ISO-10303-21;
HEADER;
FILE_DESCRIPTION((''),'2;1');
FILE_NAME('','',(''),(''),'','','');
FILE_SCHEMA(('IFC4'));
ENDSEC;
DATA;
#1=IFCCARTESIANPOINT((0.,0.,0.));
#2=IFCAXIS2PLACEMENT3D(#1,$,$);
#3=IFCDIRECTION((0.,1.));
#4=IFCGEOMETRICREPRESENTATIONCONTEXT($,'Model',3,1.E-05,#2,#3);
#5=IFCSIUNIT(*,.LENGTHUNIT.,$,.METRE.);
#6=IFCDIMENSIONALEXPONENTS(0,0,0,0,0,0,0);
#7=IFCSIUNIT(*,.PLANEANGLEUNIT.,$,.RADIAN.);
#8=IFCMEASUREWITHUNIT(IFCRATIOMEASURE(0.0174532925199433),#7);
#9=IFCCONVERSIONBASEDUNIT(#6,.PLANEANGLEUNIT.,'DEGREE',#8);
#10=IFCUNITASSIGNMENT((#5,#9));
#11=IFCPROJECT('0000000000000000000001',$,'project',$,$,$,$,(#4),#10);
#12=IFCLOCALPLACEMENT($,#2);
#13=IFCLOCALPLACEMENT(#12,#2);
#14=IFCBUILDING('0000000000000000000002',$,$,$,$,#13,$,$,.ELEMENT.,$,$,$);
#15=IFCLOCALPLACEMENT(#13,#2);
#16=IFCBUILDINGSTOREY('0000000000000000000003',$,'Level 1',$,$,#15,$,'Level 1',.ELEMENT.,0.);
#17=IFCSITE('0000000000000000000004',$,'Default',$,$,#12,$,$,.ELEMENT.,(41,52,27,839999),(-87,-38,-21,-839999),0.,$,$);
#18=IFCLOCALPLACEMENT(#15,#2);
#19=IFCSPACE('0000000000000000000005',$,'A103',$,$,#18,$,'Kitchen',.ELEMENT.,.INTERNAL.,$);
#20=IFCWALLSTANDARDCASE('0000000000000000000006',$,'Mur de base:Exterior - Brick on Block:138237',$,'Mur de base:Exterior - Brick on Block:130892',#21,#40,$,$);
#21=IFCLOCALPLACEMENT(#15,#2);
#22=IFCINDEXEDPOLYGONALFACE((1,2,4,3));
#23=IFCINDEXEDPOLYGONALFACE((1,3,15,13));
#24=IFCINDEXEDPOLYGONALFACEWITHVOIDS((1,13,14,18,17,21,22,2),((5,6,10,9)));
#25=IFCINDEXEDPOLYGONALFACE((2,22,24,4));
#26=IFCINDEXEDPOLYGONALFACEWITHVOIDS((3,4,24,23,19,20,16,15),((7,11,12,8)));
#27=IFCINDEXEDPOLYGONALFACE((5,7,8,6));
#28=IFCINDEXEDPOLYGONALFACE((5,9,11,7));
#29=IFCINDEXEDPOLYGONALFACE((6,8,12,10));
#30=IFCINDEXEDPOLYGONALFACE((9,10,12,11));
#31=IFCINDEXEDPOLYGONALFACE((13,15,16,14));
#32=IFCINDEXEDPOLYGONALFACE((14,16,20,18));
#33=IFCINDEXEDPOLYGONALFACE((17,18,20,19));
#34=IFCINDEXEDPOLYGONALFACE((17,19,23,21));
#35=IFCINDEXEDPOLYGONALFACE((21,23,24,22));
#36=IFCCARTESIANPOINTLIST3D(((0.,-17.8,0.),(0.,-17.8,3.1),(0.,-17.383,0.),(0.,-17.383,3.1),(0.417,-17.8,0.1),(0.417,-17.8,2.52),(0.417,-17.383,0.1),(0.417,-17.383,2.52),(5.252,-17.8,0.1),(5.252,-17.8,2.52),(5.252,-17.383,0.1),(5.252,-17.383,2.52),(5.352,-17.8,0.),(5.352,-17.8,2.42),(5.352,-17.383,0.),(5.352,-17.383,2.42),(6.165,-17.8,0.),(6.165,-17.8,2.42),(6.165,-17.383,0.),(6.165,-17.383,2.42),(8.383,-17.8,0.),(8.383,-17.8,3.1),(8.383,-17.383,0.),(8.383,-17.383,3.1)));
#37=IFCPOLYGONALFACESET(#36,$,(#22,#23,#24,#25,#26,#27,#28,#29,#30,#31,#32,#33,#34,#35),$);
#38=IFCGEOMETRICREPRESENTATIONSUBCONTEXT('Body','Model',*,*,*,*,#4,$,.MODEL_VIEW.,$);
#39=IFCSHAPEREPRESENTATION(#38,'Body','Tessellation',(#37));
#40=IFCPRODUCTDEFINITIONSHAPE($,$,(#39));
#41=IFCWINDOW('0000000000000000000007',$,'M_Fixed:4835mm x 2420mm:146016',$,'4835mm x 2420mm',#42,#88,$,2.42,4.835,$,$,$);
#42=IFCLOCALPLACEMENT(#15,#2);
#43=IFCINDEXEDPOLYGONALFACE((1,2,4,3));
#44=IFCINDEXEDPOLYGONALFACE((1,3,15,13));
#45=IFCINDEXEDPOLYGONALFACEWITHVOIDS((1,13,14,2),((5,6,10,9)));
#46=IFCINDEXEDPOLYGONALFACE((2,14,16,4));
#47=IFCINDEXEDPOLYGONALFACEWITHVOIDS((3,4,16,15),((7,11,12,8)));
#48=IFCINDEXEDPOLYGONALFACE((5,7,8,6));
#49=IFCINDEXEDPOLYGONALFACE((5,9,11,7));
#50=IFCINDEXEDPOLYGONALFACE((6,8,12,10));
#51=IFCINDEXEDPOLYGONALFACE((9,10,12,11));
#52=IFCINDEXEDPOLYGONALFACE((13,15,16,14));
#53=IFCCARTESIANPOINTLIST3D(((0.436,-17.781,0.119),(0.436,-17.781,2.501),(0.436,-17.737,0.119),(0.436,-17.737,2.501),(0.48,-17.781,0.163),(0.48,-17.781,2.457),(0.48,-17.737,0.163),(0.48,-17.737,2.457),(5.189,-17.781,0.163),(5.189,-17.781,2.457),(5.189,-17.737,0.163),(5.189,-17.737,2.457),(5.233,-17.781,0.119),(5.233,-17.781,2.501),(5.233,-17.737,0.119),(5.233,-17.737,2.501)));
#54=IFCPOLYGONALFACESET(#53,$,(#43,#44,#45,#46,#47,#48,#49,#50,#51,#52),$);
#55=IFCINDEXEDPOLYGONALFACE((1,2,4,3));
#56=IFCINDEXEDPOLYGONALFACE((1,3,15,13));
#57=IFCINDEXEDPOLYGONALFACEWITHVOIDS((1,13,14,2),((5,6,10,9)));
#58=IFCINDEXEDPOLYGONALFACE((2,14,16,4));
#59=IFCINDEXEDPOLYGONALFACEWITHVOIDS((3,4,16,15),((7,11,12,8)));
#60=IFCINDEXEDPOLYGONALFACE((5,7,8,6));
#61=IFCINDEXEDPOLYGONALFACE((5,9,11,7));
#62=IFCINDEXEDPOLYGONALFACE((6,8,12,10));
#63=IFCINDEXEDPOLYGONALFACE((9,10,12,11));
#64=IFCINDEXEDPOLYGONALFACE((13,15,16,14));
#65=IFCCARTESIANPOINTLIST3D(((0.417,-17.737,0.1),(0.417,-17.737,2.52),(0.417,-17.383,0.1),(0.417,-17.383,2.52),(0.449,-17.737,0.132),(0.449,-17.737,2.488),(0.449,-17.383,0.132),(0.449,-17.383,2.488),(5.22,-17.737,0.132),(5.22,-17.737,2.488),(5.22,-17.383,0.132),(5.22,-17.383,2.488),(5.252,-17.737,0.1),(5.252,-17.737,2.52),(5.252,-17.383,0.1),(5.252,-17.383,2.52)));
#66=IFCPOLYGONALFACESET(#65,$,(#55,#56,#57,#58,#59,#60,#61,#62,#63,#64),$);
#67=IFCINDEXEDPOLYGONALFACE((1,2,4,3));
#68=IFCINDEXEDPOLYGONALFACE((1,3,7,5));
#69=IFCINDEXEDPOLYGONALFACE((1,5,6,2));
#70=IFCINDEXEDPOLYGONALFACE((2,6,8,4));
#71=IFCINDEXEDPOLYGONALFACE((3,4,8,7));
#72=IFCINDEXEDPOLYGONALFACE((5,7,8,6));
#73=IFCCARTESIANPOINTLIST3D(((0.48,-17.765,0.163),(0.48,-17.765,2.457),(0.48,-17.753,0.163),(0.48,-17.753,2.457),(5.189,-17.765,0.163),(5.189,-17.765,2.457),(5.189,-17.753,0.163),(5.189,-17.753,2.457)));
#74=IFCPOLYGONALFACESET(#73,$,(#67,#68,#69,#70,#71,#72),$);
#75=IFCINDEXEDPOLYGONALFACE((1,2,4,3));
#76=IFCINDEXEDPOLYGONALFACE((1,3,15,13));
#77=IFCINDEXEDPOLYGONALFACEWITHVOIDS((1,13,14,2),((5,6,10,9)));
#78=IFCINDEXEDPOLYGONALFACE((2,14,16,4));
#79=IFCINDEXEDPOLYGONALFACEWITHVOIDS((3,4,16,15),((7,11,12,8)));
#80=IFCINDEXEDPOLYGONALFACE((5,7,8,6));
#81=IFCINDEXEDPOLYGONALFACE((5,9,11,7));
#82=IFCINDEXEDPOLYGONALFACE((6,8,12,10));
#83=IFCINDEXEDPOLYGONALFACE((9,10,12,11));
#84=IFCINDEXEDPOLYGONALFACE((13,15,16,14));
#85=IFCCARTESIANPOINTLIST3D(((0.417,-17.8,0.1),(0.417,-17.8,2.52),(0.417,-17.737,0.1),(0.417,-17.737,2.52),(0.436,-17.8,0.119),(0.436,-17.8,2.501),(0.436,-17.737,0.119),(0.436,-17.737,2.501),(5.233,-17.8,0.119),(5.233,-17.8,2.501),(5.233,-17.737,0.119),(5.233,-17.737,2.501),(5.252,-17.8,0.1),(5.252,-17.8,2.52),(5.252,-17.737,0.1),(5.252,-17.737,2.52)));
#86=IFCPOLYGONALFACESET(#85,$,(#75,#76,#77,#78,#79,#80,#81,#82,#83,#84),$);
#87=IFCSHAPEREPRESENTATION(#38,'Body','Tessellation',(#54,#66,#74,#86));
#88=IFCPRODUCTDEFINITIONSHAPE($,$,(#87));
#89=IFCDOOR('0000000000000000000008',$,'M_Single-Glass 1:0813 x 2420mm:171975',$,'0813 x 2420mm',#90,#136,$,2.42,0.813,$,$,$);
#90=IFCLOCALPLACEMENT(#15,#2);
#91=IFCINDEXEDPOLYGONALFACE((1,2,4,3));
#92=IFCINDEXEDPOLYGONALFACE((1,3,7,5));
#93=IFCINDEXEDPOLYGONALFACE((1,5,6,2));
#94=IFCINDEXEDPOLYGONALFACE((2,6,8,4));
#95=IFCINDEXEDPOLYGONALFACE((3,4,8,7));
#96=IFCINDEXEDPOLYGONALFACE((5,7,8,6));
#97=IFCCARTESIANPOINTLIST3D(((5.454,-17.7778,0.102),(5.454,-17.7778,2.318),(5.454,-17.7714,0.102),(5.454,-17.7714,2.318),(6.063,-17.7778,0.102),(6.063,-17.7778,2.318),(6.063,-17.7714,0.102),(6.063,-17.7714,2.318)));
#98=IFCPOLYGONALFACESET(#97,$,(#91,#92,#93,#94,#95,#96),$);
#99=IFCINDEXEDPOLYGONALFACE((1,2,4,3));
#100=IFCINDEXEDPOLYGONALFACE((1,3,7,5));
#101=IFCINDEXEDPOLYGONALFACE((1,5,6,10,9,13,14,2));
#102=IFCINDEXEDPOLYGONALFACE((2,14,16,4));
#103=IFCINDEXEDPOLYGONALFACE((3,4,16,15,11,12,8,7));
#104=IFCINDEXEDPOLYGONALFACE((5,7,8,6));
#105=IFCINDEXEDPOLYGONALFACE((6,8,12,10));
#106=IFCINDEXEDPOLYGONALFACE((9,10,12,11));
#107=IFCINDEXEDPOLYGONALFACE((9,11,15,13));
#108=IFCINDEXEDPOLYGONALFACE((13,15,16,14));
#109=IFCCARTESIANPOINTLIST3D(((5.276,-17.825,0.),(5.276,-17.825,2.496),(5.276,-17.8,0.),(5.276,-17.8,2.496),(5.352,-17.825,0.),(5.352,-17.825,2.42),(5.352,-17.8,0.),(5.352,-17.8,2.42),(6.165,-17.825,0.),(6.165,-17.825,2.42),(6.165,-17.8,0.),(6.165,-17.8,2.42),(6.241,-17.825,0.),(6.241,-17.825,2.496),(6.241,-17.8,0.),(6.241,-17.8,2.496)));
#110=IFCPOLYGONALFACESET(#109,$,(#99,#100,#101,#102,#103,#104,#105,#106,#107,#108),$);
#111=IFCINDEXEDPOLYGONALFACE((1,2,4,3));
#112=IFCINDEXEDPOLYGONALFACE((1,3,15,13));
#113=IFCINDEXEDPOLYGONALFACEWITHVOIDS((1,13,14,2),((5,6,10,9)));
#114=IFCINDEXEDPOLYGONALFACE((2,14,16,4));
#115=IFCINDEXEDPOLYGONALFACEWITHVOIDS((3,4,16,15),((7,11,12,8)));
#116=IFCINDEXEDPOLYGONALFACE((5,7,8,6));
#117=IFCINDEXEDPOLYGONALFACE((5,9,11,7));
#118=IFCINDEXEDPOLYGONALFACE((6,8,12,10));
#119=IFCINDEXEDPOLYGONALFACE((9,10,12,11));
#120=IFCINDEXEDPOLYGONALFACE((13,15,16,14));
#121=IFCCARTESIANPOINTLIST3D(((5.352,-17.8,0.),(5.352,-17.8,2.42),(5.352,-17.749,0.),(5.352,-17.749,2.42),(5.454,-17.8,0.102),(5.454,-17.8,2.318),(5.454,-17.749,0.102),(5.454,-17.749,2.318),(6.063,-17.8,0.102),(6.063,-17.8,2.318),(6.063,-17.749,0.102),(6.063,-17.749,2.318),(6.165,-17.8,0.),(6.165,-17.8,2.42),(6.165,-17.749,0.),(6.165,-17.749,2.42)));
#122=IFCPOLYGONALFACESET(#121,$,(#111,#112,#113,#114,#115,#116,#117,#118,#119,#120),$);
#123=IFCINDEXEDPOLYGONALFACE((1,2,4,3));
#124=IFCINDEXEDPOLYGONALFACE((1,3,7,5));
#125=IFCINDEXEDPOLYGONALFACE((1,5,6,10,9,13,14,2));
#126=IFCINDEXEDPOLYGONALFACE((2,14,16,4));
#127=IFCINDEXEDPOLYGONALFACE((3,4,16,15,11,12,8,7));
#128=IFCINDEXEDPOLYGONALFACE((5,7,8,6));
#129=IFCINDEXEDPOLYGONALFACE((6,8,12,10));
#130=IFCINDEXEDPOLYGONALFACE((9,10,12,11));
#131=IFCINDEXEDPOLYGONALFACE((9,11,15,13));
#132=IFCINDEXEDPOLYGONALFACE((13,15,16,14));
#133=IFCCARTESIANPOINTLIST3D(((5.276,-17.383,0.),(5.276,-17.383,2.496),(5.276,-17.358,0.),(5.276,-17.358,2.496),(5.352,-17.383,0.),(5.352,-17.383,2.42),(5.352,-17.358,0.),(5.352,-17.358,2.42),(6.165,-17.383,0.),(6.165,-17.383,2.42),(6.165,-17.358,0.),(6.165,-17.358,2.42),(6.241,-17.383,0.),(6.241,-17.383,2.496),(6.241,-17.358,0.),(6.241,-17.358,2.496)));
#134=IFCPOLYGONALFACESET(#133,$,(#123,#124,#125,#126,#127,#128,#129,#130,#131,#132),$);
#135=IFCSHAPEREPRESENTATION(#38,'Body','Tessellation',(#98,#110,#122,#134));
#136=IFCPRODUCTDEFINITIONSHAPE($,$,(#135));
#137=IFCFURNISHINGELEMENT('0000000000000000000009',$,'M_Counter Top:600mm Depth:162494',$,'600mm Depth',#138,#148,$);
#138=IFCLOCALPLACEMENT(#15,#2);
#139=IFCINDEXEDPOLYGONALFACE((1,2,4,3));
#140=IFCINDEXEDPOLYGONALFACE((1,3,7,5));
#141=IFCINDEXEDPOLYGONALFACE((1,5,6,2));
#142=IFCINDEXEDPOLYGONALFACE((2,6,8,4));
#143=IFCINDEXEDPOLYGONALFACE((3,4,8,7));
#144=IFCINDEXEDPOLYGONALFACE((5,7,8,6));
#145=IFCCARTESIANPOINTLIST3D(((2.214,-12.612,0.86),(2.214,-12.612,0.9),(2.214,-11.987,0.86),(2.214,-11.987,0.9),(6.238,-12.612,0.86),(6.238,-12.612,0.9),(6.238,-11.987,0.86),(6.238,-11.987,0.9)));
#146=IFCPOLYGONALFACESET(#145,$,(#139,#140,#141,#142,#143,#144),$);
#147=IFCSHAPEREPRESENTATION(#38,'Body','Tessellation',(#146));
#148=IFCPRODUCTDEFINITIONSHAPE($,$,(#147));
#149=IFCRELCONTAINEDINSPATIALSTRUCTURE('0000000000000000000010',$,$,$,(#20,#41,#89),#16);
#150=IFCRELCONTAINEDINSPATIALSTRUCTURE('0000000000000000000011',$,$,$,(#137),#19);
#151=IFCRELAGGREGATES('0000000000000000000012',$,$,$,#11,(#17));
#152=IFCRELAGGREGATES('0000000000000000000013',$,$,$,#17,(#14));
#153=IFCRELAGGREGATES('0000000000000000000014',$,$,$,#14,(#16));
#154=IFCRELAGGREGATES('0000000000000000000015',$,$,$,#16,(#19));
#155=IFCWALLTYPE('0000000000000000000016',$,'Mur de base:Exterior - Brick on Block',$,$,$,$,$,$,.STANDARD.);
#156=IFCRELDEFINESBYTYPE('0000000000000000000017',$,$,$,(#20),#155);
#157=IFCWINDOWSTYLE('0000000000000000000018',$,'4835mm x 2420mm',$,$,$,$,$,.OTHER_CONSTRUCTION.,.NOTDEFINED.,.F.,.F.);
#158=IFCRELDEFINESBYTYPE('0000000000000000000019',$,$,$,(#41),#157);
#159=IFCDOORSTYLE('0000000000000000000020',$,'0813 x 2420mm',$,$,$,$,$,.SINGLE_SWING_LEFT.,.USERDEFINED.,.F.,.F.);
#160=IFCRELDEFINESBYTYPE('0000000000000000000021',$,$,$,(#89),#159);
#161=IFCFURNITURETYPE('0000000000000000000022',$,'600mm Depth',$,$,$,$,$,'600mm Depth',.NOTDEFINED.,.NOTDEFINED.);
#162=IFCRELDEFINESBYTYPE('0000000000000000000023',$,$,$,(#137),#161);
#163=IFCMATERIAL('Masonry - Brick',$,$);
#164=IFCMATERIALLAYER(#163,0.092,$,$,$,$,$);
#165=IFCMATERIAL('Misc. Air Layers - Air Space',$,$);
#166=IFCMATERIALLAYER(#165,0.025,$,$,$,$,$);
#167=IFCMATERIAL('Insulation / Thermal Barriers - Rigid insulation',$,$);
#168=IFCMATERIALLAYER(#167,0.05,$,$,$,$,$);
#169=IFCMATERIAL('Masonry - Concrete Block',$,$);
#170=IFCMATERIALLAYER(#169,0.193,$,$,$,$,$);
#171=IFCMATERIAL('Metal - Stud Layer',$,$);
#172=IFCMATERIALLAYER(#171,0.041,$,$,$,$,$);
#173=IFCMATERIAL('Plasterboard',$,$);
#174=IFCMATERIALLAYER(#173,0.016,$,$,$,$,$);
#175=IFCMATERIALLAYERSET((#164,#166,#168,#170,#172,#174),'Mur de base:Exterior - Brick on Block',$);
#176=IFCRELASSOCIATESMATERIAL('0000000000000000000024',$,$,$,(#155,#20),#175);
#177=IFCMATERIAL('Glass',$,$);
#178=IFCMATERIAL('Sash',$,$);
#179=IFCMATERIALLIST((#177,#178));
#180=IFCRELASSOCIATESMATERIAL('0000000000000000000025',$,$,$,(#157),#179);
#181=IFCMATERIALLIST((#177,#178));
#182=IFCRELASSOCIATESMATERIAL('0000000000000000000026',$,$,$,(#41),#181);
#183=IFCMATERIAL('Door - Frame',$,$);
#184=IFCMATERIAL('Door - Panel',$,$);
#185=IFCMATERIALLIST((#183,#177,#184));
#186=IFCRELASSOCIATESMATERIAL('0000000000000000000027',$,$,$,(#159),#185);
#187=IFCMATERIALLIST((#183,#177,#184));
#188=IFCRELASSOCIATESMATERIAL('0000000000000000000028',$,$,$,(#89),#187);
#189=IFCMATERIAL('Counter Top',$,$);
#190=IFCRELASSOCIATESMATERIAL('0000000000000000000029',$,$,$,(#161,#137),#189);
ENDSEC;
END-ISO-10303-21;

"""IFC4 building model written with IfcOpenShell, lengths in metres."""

from ifc_helpers import new_model, entity, si_unit, converted_unit, direction, frame, frame_2d, origin, origin_2d_with_axis, place, context, subcontext, project, spatial, polyline, rectangle, outline, extrude, source, transform, mapped, material, material_list, layer, layer_set, layer_usage, type_object, type_shapes, element, fill, save


model = new_model("IFC4")

# Units and contexts
model_context = context("Model", 3, precision=1e-05, world=origin(), true_north=direction((0.0, 1.0)))
body_context = subcontext(model_context, "Body", "Model", "MODEL_VIEW")
ifc_project = project(units=[si_unit("LENGTHUNIT", "METRE"), converted_unit("PLANEANGLEUNIT", "DEGREE", entity("IfcRatioMeasure", 0.0174532925199433), si_unit("PLANEANGLEUNIT", "RADIAN"), dimensions=[0, 0, 0, 0, 0, 0, 0])], contexts=[model_context])

# Site, building, storey
site_placement = place(None, origin())
site = spatial("IfcSite", under=ifc_project, at=site_placement, Name="Default", CompositionType="ELEMENT", RefLatitude=(41, 52, 27, 839999), RefLongitude=(-87, -38, -21, -839999), RefElevation=0.0)
building_placement = place(site_placement, origin())
building = spatial("IfcBuilding", under=site, at=building_placement, CompositionType="ELEMENT")
storey_placement = place(building_placement, origin())
storey = spatial("IfcBuildingStorey", under=building, at=storey_placement, Name="Level 1", LongName="Level 1", CompositionType="ELEMENT", Elevation=0.0)

# Shared definitions
ifc_material_1 = material(Name="Plasterboard")
ifc_material_2 = material(Name="Metal - Stud Layer")
ifc_material_3 = material(Name="Door - Frame")
ifc_material_4 = material(Name="Door - Panel")

# Wall, openings, window, door
ifc_material_5 = material(Name="Masonry - Brick")
ifc_layer_1 = layer(ifc_material_5, 0.092)
ifc_material_6 = material(Name="Misc. Air Layers - Air Space")
ifc_layer_2 = layer(ifc_material_6, 0.025)
ifc_material_7 = material(Name="Insulation / Thermal Barriers - Rigid insulation")
ifc_layer_3 = layer(ifc_material_7, 0.05)
ifc_material_8 = material(Name="Masonry - Concrete Block")
ifc_layer_4 = layer(ifc_material_8, 0.193)
ifc_layer_5 = layer(ifc_material_2, 0.041)
ifc_layer_6 = layer(ifc_material_1, 0.016)
ifc_layer_set_1 = layer_set([ifc_layer_1, ifc_layer_2, ifc_layer_3, ifc_layer_4, ifc_layer_5, ifc_layer_6], Name="Mur de base:Exterior - Brick on Block")
wall_type_1 = type_object("IfcWallType", Name="Mur de base:Exterior - Brick on Block", PredefinedType="STANDARD", material=ifc_layer_set_1)
ifc_material_9 = material(Name="Glass")
ifc_material_10 = material(Name="Sash")
ifc_layer_usage_1 = layer_usage(ifc_layer_set_1, "AXIS2", "NEGATIVE", 0.2085)
wall_1_placement = place(storey_placement, frame((8.383, -17.5915, 0.0), z_axis=(0.0, 0.0, 1.0), x_axis=(-1.0, 0.0, 0.0)))
wall_1 = element("IfcWallStandardCase", 1, at=wall_1_placement, inside=storey, type_object=wall_type_1, material=ifc_layer_usage_1, Name="Mur de base:Exterior - Brick on Block:138237", ObjectType="Mur de base:Exterior - Brick on Block:130892", context=body_context, shape_type="SweptSolid", body=[
    extrude(rectangle(XDim=8.383, YDim=0.417, at=frame_2d((4.1915, 0.0), x_axis=(-1.0, 0.0))), origin(), (0.0, 0.0, 1.0), 3.1),
])
opening_1_placement = place(wall_1_placement, frame((2.218, -0.2085, 0.0)))
opening_1 = element("IfcOpeningElement", 2, at=opening_1_placement, cuts=wall_1, ObjectType="Opening", context=body_context, shape_type="SweptSolid", body=[
    extrude(rectangle(XDim=0.813, YDim=2.42, at=frame_2d((1.21, 0.4065), x_axis=(0.0, -1.0))), frame((0.0, 0.0, 0.0), z_axis=(0.0, 1.0, 0.0), x_axis=(0.0, 0.0, 1.0)), (0.0, 0.0, 1.0), 0.417),
])
opening_2_placement = place(wall_1_placement, frame((3.131, -0.2085, 0.1)))
opening_2 = element("IfcOpeningElement", 3, at=opening_2_placement, cuts=wall_1, ObjectType="Opening", context=body_context, shape_type="SweptSolid", body=[
    extrude(rectangle(XDim=2.42, YDim=4.835, at=frame_2d((1.21, 2.4175), x_axis=(1.0, 0.0))), frame((0.0, 0.0, 0.0), z_axis=(0.0, 1.0, 0.0), x_axis=(0.0, 0.0, 1.0)), (0.0, 0.0, 1.0), 0.417),
])
ifc_material_list_1 = material_list([ifc_material_9, ifc_material_10])
ifc_material_list_2 = material_list([ifc_material_9, ifc_material_10])
window_style_1 = type_object("IfcWindowStyle", Name="4835mm x 2420mm", ConstructionType="OTHER_CONSTRUCTION", OperationType="NOTDEFINED", ParameterTakesPrecedence=False, Sizeable=False, material=ifc_material_list_2)
shared_shape_1 = source(origin(), body_context, "Body", "SweptSolid", [
    extrude(outline(polyline([(-2.3985, -1.191), (2.3985, -1.191), (2.3985, 1.191), (-2.3985, 1.191), (-2.3985, -1.191)]), holes=[polyline([(-2.3545, -1.147), (-2.3545, 1.147), (2.3545, 1.147), (2.3545, -1.147), (-2.3545, -1.147)])]), frame((2.4175, 0.354, 1.21), z_axis=(0.0, 1.0, 0.0), x_axis=(1.0, 0.0, 0.0)), (0.0, 0.0, 1.0), 0.044),
    extrude(outline(polyline([(-2.4175, -1.21), (2.4175, -1.21), (2.4175, 1.21), (-2.4175, 1.21), (-2.4175, -1.21)]), holes=[polyline([(-2.3855, -1.178), (-2.3855, 1.178), (2.3855, 1.178), (2.3855, -1.178), (-2.3855, -1.178)])]), frame((2.4175, 0.0, 1.21), z_axis=(0.0, 1.0, 0.0), x_axis=(1.0, 0.0, 0.0)), (0.0, 0.0, 1.0), 0.354),
    extrude(rectangle(XDim=0.012, YDim=4.709, at=origin_2d_with_axis()), frame((2.4175, 0.376, 0.063), z_axis=(0.0, 0.0, 1.0), x_axis=(0.0, -1.0, 0.0)), (0.0, 0.0, 1.0), 2.294),
    extrude(outline(polyline([(-2.4175, -1.21), (2.4175, -1.21), (2.4175, 1.21), (-2.4175, 1.21), (-2.4175, -1.21)]), holes=[polyline([(-2.3985, -1.191), (-2.3985, 1.191), (2.3985, 1.191), (2.3985, -1.191), (-2.3985, -1.191)])]), frame((2.4175, 0.354, 1.21), z_axis=(0.0, 1.0, 0.0), x_axis=(1.0, 0.0, 0.0)), (0.0, 0.0, 1.0), 0.063),
])
type_shapes(window_style_1, [shared_shape_1])
window_1_placement = place(opening_2_placement, origin())
window_1 = element("IfcWindow", 4, at=window_1_placement, inside=storey, type_object=window_style_1, material=ifc_material_list_1, Name="M_Fixed:4835mm x 2420mm:146016", ObjectType="4835mm x 2420mm", OverallHeight=2.42, OverallWidth=4.835, context=body_context, shape_type="MappedRepresentation", body=[
    mapped(shared_shape_1, transform((0.0, 0.0, 0.0), scale=1.0)),
])
fill(opening_2, window_1)
ifc_material_list_3 = material_list([ifc_material_3, ifc_material_9, ifc_material_4])
ifc_material_list_4 = material_list([ifc_material_3, ifc_material_9, ifc_material_4])
door_style_1 = type_object("IfcDoorStyle", Name="0813 x 2420mm", ConstructionType="USERDEFINED", OperationType="SINGLE_SWING_LEFT", ParameterTakesPrecedence=False, Sizeable=False, material=ifc_material_list_4)
shared_shape_2 = source(origin(), body_context, "Body", "SweptSolid", [
    extrude(rectangle(XDim=0.609, YDim=0.0064, at=frame_2d((0.0, 0.0), x_axis=(1.0, 0.0))), frame((0.4065, 0.3916, 0.102)), (0.0, 0.0, 1.0), 2.216),
    extrude(outline(polyline([(-0.4065, -1.191), (-0.4065, 1.229), (-0.4825, 1.229), (-0.4825, -1.267), (0.4825, -1.267), (0.4825, 1.229), (0.4065, 1.229), (0.4065, -1.191), (-0.4065, -1.191)])), frame((0.4065, 0.442, 1.229), z_axis=(0.0, 1.0, 0.0), x_axis=(1.0, 0.0, 0.0)), (0.0, 0.0, -1.0), 0.025),
    extrude(outline(polyline([(-1.21, -0.4065), (1.21, -0.4065), (1.21, 0.4065), (-1.21, 0.4065), (-1.21, -0.4065)]), holes=[polyline([(-1.108, 0.3045), (1.108, 0.3045), (1.108, -0.3045), (-1.108, -0.3045), (-1.108, 0.3045)])]), frame((0.4065, 0.417, 1.21), z_axis=(0.0, -1.0, 0.0), x_axis=(0.0, 0.0, -1.0)), (0.0, 0.0, 1.0), 0.051),
    extrude(outline(polyline([(-0.4065, -1.191), (-0.4065, 1.229), (-0.4825, 1.229), (-0.4825, -1.267), (0.4825, -1.267), (0.4825, 1.229), (0.4065, 1.229), (0.4065, -1.191), (-0.4065, -1.191)])), frame((0.4065, 0.0, 1.229), z_axis=(0.0, 1.0, 0.0), x_axis=(1.0, 0.0, 0.0)), (0.0, 0.0, -1.0), 0.025),
])
type_shapes(door_style_1, [shared_shape_2])
door_1_placement = place(opening_1_placement, origin())
door_1 = element("IfcDoor", 5, at=door_1_placement, inside=storey, type_object=door_style_1, material=ifc_material_list_3, Name="M_Single-Glass 1:0813 x 2420mm:171975", ObjectType="0813 x 2420mm", OverallHeight=2.42, OverallWidth=0.813, context=body_context, shape_type="MappedRepresentation", body=[
    mapped(shared_shape_2, transform((0.0, 0.0, 0.0), scale=1.0)),
])
fill(opening_1, door_1)

# Shared definitions
space_1_placement = place(storey_placement, origin())
space_1 = spatial("IfcSpace", under=storey, at=space_1_placement, Name="A103", LongName="Kitchen", CompositionType="ELEMENT", PredefinedType="INTERNAL")

# Furnishing element
ifc_material_11 = material(Name="Counter Top")
furniture_type_1 = type_object("IfcFurnitureType", Name="600mm Depth", ElementType="600mm Depth", AssemblyPlace="NOTDEFINED", material=ifc_material_11)
shared_shape_3 = source(origin(), body_context, "Body", "SweptSolid", [
    extrude(rectangle(XDim=4.024, YDim=0.625, at=frame_2d((0.0, 0.0), x_axis=(1.0, 0.0))), frame((0.8115, -0.3125, 0.86), z_axis=(0.0, 0.0, 1.0), x_axis=(-1.0, 0.0, 0.0)), (0.0, 0.0, 1.0), 0.04),
])
type_shapes(furniture_type_1, [shared_shape_3])
furnishing_1_placement = place(space_1_placement, frame((5.0375, -12.612, 0.0), z_axis=(0.0, 0.0, 1.0), x_axis=(-1.0, 0.0, 0.0)))
element("IfcFurnishingElement", 6, at=furnishing_1_placement, inside=space_1, type_object=furniture_type_1, material=ifc_material_11, Name="M_Counter Top:600mm Depth:162494", ObjectType="600mm Depth", context=body_context, shape_type="MappedRepresentation", body=[
    mapped(shared_shape_3, transform((0.0, 0.0, 0.0), scale=1.0)),
])

save(model, "model.ifc")
